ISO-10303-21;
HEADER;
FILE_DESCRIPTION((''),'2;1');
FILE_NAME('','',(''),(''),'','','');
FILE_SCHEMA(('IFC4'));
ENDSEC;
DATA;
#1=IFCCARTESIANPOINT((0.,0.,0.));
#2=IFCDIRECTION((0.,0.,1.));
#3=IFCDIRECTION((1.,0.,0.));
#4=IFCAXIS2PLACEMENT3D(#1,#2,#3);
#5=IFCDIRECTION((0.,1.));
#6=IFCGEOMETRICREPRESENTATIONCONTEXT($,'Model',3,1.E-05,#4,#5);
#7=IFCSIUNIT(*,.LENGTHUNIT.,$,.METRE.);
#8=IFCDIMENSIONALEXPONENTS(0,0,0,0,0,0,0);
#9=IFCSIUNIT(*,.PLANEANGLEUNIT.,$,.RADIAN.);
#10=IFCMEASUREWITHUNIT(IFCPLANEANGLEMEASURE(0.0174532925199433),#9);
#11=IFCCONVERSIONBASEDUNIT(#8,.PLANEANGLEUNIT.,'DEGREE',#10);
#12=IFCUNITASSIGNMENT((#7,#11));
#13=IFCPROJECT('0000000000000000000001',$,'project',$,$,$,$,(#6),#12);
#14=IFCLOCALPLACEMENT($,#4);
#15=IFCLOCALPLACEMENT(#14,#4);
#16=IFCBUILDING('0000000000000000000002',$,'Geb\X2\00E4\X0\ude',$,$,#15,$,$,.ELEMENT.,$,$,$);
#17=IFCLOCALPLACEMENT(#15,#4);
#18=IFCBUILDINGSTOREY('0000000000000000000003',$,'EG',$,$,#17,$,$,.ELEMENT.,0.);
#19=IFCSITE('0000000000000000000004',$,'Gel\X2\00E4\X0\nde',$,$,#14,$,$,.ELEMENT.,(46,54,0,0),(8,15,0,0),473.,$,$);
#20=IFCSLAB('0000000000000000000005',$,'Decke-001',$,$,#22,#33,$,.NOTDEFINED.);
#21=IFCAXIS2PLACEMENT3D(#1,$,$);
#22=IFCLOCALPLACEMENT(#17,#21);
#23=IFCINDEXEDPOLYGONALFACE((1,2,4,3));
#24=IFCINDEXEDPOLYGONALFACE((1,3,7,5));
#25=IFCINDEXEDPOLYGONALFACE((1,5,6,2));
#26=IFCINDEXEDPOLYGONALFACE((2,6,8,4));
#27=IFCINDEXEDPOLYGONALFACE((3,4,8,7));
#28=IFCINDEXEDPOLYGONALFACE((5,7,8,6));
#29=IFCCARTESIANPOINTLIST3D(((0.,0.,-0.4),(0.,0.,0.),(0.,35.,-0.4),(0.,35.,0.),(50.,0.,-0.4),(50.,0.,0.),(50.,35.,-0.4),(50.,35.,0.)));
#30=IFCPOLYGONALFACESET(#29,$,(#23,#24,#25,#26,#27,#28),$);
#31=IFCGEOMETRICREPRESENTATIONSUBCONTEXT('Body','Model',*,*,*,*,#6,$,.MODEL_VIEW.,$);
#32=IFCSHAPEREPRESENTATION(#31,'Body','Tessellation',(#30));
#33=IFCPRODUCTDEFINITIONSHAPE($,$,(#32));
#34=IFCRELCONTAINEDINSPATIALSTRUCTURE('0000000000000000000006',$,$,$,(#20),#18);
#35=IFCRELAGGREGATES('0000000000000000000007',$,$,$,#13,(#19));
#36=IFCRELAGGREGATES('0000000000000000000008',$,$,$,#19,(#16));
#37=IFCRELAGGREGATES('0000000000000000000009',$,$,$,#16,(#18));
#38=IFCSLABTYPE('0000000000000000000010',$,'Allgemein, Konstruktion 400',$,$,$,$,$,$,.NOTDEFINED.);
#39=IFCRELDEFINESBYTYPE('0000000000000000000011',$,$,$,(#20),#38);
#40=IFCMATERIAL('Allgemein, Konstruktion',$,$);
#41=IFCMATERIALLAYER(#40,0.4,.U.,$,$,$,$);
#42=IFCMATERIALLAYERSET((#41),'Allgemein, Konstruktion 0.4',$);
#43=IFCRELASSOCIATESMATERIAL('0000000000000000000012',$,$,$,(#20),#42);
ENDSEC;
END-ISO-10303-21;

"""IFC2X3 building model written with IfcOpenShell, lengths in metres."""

from ifc_helpers import new_model, entity, si_unit, converted_unit, direction, frame, origin_with_axes, place, context, subcontext, project, spatial, polyline, outline, extrude, material, layer, layer_set, layer_usage, type_object, element, save


model = new_model("IFC2X3")

# Units and contexts
model_context = context("Model", 3, precision=1e-05, world=origin_with_axes(), true_north=direction((0.0, 1.0)))
body_context = subcontext(model_context, "Body", "Model", "MODEL_VIEW")
ifc_project = project(units=[si_unit("LENGTHUNIT", "METRE"), converted_unit("PLANEANGLEUNIT", "DEGREE", entity("IfcPlaneAngleMeasure", 0.0174532925199433), si_unit("PLANEANGLEUNIT", "RADIAN"), dimensions=[0, 0, 0, 0, 0, 0, 0])], contexts=[model_context])

# Site, building, storey
site_placement = place(None, origin_with_axes())
site = spatial("IfcSite", under=ifc_project, at=site_placement, Name="Gelände", CompositionType="ELEMENT", RefLatitude=(46, 54, 0, 0), RefLongitude=(8, 15, 0, 0), RefElevation=473.0)
building_placement = place(site_placement, origin_with_axes())
building = spatial("IfcBuilding", under=site, at=building_placement, Name="Gebäude", CompositionType="ELEMENT")
storey_placement = place(building_placement, origin_with_axes())
storey = spatial("IfcBuildingStorey", under=building, at=storey_placement, Name="EG", CompositionType="ELEMENT", Elevation=0.0)

# Slab
ifc_material = material(Name="Allgemein, Konstruktion")
ifc_layer = layer(ifc_material, 0.4, ventilated="UNKNOWN")
ifc_layer_set = layer_set([ifc_layer], Name="Allgemein, Konstruktion 0.4")
ifc_layer_usage = layer_usage(ifc_layer_set, "AXIS3", "NEGATIVE", 0.4)
slab_type = type_object("IfcSlabType", Name="Allgemein, Konstruktion 400", PredefinedType="NOTDEFINED")
slab_placement = place(storey_placement, origin_with_axes())
element("IfcSlab", 1, at=slab_placement, inside=storey, type_object=slab_type, material=ifc_layer_usage, Name="Decke-001", PredefinedType="NOTDEFINED", context=body_context, shape_type="SweptSolid", body=[
    extrude(outline(polyline([(0.0, 0.0), (50.0, 0.0), (50.0, 35.0), (0.0, 35.0), (0.0, 0.0)])), frame((0.0, 0.0, -0.4), z_axis=(0.0, 0.0, 1.0), x_axis=(1.0, 0.0, 0.0)), (0.0, 0.0, 1.0), 0.4),
])

save(model, "model.ifc")
